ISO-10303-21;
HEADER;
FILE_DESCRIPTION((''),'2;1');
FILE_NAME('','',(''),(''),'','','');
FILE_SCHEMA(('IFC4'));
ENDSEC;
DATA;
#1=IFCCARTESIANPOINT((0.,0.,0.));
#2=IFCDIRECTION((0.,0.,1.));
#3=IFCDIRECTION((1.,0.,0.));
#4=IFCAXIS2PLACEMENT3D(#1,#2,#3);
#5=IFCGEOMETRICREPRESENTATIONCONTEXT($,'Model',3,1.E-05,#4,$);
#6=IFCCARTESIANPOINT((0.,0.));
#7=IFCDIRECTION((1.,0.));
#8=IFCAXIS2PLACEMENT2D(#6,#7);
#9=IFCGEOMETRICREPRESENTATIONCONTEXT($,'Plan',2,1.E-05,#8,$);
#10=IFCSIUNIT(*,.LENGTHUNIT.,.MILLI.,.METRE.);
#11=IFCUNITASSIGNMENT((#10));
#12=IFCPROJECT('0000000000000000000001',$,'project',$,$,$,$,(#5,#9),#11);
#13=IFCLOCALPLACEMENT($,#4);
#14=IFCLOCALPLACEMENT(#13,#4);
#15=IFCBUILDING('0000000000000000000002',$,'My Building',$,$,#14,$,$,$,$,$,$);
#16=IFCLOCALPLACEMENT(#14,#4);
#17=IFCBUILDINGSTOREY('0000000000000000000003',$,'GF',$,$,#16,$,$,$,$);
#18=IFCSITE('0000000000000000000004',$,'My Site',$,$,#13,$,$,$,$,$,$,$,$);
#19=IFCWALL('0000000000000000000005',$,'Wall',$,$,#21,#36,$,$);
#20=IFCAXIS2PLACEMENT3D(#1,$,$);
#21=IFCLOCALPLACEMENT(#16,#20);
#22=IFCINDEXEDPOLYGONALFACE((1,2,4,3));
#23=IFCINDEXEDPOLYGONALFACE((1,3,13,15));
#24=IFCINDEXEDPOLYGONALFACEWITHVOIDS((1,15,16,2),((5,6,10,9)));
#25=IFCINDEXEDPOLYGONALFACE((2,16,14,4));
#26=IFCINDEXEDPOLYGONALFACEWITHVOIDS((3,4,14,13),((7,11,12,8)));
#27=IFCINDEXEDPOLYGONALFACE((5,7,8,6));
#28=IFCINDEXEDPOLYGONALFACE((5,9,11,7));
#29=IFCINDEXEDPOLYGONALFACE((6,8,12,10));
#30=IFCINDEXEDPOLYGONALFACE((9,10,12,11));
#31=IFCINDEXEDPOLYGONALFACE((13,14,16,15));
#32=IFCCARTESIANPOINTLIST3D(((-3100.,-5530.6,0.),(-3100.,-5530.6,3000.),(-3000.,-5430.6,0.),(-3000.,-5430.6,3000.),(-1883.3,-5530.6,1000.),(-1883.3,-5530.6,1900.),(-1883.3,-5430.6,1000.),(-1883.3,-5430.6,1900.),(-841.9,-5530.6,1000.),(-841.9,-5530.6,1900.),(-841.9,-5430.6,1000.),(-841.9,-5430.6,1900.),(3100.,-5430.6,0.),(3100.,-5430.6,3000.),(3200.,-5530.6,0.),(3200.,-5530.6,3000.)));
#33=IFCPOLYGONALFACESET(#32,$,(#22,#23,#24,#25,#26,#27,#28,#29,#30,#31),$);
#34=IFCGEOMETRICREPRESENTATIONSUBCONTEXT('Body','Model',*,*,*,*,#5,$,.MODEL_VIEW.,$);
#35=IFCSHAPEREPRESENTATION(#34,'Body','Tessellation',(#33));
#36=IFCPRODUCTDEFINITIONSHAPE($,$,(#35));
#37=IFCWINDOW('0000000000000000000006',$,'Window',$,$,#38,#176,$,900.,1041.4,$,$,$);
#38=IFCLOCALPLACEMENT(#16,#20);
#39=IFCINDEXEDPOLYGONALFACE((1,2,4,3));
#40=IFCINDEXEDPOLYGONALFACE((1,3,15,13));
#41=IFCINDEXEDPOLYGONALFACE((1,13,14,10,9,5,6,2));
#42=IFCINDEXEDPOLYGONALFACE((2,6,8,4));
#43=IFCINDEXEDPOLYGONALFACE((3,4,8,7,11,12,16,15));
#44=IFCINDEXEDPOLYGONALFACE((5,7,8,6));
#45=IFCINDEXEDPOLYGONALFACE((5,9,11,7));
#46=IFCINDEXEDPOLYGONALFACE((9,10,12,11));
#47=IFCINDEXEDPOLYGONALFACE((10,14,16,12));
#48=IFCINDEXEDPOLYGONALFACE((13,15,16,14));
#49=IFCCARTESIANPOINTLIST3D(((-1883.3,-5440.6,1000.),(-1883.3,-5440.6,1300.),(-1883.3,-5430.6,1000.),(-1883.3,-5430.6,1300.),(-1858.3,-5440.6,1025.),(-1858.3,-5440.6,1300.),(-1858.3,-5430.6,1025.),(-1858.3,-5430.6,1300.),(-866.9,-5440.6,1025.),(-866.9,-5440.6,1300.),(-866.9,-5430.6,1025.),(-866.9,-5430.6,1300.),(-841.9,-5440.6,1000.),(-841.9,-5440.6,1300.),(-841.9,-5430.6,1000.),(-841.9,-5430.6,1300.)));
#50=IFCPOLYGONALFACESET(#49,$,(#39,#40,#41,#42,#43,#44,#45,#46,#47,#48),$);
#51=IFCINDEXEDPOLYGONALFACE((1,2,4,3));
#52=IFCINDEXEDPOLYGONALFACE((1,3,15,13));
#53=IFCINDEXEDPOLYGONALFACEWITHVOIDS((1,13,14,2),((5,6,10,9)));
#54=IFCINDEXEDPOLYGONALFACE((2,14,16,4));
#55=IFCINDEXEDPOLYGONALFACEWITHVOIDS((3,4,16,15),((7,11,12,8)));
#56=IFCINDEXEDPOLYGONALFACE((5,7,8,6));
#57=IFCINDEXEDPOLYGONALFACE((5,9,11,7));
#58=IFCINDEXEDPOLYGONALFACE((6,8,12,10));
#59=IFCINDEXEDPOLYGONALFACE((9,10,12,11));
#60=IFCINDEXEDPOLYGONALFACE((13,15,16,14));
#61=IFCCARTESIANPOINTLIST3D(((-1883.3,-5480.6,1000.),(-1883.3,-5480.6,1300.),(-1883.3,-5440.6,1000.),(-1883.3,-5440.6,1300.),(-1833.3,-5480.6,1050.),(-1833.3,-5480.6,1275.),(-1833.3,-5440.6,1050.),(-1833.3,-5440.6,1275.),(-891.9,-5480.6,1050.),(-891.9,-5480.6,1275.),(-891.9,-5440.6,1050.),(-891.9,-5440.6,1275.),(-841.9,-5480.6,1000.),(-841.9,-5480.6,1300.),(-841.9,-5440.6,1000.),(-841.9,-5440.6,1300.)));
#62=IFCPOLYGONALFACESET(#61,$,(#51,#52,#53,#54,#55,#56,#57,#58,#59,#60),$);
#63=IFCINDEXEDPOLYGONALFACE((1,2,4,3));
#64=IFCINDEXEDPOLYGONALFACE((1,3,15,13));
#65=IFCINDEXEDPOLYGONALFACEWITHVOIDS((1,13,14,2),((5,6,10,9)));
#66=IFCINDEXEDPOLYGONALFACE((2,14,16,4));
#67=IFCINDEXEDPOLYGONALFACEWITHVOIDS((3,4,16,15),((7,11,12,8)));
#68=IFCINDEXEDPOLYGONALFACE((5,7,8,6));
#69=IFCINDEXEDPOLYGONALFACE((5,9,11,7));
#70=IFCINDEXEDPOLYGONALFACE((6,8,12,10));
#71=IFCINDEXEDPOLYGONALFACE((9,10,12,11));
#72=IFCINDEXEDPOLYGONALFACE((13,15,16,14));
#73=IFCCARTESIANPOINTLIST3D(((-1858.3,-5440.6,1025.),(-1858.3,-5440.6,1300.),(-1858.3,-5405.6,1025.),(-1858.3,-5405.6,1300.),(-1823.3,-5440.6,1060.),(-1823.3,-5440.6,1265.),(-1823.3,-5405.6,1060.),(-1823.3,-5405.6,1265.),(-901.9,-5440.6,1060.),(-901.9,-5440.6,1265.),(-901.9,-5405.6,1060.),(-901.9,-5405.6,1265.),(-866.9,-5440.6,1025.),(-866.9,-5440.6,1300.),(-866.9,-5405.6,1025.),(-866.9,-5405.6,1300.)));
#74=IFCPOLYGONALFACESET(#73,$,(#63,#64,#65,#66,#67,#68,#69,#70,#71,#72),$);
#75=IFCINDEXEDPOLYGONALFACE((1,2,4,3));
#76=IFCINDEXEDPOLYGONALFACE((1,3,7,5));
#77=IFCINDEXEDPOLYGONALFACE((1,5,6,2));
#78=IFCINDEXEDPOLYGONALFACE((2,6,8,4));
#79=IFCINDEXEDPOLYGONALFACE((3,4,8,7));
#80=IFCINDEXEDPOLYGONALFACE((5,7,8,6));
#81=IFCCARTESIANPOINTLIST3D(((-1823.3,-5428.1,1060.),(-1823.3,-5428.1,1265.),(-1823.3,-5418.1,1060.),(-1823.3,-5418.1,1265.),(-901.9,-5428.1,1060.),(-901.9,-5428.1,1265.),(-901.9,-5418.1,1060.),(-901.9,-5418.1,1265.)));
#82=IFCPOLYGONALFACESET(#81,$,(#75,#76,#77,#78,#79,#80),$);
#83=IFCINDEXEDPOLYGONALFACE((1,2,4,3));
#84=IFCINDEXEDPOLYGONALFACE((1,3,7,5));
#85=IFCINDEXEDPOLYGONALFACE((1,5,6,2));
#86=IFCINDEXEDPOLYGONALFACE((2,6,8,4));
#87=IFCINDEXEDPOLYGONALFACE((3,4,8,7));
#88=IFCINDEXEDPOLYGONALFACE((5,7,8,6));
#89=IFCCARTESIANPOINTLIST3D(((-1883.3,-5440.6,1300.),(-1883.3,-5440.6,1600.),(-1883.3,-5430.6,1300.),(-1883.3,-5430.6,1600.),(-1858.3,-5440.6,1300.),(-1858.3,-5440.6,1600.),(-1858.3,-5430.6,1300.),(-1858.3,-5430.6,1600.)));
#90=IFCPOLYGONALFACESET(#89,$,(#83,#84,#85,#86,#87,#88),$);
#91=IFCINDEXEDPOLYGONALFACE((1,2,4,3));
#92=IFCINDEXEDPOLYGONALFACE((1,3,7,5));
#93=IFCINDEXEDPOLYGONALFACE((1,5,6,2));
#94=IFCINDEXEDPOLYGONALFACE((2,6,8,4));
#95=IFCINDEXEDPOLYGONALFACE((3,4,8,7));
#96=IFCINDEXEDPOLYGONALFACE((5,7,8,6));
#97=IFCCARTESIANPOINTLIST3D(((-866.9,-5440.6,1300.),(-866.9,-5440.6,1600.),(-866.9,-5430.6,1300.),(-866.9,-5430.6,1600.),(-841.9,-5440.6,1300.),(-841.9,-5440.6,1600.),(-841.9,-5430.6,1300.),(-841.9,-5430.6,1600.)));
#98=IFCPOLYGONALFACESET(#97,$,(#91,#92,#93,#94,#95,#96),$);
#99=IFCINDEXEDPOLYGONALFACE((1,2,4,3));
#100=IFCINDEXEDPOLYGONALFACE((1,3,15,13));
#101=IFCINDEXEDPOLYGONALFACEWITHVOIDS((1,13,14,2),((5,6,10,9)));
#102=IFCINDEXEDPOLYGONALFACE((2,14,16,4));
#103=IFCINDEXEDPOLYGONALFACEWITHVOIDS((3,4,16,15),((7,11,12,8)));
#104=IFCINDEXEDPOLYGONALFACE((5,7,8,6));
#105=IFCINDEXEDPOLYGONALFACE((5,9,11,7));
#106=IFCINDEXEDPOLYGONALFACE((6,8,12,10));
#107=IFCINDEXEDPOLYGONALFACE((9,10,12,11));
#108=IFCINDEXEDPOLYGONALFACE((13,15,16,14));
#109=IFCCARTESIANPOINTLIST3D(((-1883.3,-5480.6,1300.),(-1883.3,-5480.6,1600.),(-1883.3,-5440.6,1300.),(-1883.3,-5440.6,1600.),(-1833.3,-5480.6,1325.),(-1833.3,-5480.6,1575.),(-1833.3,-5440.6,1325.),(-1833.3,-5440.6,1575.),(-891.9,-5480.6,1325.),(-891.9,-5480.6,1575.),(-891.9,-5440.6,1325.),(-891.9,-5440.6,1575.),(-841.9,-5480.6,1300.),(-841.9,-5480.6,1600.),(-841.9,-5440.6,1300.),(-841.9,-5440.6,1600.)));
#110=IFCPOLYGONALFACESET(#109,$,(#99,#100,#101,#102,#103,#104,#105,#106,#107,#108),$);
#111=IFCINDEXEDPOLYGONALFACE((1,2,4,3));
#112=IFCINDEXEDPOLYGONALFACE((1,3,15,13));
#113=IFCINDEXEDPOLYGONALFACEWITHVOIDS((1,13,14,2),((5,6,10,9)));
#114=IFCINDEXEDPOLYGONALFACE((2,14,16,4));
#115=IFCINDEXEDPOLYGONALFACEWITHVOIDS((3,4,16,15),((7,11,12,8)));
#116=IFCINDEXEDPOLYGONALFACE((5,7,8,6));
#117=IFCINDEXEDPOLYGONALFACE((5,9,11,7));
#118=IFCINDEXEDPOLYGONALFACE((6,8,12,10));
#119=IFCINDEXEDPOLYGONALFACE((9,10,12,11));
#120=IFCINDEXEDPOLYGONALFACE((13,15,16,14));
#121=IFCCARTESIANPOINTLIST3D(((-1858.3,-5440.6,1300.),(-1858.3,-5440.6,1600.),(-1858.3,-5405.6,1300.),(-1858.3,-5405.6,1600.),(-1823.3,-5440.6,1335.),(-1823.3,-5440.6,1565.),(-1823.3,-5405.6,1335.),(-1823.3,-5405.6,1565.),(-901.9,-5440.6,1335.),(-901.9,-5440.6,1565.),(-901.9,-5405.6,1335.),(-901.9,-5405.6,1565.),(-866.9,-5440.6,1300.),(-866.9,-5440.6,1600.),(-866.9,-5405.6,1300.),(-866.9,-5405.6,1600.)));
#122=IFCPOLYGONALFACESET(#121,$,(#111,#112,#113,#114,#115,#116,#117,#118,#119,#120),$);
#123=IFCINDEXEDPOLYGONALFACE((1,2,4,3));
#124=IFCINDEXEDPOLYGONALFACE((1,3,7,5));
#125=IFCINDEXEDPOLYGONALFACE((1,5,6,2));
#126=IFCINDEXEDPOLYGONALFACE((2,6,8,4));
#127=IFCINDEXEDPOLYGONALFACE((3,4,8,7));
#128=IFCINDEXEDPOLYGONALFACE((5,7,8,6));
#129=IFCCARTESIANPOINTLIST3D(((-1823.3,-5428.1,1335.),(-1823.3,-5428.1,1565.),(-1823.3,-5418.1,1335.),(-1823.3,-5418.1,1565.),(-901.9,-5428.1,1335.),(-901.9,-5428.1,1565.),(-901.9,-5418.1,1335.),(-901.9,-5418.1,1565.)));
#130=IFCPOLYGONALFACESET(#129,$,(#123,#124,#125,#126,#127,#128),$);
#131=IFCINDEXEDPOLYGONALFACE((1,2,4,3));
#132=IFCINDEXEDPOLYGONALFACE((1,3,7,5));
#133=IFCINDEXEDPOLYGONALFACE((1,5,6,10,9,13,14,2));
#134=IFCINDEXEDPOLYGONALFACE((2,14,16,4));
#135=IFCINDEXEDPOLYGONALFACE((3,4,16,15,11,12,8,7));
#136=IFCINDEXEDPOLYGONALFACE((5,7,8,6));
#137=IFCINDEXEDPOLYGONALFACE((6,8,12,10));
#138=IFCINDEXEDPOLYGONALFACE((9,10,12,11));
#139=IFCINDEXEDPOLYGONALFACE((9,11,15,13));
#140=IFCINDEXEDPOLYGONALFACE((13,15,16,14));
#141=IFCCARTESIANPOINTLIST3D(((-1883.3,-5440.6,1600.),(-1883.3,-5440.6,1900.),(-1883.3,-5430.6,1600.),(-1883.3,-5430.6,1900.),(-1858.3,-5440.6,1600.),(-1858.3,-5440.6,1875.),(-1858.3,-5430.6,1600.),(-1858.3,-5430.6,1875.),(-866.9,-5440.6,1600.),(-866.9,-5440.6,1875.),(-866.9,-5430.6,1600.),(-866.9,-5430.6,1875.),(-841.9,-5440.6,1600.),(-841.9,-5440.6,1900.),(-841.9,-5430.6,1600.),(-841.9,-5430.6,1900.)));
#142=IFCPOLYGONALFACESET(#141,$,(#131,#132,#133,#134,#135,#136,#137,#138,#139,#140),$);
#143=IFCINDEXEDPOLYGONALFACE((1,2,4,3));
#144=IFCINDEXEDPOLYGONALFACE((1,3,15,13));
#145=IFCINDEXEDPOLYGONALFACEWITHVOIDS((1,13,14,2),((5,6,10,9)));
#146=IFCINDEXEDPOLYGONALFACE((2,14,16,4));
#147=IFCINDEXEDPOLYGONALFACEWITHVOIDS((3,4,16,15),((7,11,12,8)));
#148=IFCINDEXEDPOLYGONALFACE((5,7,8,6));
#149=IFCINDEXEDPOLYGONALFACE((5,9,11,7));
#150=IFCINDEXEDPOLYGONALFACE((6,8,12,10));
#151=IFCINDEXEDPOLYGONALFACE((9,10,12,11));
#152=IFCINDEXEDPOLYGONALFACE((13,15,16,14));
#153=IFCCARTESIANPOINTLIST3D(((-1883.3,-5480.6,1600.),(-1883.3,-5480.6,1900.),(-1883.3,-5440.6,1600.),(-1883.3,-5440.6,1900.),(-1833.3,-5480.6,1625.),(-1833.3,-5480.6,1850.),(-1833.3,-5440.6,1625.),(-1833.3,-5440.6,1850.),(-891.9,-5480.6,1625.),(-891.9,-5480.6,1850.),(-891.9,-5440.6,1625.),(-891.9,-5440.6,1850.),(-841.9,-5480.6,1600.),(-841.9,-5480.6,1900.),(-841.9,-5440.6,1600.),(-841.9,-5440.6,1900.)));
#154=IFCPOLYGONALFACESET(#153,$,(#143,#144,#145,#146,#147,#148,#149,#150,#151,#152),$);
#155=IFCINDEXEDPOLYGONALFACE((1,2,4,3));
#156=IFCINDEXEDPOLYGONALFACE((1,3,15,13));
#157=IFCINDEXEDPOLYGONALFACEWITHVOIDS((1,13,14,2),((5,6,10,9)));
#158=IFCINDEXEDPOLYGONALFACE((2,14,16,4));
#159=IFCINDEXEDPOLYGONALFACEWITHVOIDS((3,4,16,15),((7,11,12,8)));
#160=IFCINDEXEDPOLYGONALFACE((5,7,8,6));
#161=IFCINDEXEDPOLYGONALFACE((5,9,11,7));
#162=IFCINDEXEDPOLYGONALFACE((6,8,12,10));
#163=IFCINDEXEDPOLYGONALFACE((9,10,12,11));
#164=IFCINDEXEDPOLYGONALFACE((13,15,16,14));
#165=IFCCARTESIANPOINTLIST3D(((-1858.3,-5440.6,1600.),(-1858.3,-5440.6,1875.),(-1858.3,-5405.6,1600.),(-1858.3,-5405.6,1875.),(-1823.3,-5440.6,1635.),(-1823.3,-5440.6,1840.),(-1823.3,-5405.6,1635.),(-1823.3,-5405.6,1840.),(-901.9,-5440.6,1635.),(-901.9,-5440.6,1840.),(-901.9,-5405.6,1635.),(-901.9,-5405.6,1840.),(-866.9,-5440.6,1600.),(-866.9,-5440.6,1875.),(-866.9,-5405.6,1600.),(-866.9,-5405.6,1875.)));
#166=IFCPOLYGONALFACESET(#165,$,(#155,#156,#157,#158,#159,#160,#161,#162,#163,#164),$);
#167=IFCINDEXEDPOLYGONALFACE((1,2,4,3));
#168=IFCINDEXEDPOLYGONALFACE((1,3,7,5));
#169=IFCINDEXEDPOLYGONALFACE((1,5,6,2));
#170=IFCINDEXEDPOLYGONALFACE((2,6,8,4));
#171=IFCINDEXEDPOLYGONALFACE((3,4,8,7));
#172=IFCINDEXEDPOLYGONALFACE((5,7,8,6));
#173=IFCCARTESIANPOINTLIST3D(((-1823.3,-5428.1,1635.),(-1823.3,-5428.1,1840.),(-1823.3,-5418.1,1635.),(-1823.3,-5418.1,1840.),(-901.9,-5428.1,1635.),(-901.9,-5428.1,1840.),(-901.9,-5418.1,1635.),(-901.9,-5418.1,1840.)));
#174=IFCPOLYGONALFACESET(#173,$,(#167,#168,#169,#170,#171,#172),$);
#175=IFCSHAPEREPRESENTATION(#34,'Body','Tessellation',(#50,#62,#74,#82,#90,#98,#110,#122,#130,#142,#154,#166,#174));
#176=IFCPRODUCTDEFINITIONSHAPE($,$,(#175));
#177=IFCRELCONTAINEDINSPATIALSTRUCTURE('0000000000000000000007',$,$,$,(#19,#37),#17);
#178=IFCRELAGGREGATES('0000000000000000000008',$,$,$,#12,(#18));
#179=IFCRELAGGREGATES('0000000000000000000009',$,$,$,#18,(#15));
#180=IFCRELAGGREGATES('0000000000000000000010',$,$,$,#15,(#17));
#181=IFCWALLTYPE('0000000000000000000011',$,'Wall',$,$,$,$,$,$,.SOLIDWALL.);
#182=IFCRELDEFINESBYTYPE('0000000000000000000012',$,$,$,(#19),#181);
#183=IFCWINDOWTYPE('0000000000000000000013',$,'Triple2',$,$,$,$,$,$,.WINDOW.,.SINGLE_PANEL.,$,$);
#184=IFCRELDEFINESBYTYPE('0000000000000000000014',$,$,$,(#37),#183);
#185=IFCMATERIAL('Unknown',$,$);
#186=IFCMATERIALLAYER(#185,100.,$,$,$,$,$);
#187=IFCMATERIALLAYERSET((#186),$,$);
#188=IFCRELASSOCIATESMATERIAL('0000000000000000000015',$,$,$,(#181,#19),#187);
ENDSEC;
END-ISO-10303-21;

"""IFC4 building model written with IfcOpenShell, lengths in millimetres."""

from ifc_helpers import new_model, entity, si_unit, frame, origin_with_axes, origin_2d_with_axis, place, context, subcontext, project, spatial, line, indexed_curve, outline, extrude, shape, source, transform, mapped, material, layer, layer_set, layer_usage, type_object, type_shapes, element, fill, save


model = new_model("IFC4")

# Units and contexts
model_context = context("Model", 3, precision=1e-05, world=origin_with_axes())
plan_context = context("Plan", 2, precision=1e-05, world=origin_2d_with_axis())
body_context_1 = subcontext(model_context, "Body", "Model", "MODEL_VIEW")
body_context_2 = subcontext(plan_context, "Body", "Plan", "PLAN_VIEW")
ifc_project = project(units=[si_unit("LENGTHUNIT", "METRE", prefix="MILLI")], contexts=[model_context, plan_context])

# Site, building, storey
site_placement = place(None, origin_with_axes())
site = spatial("IfcSite", under=ifc_project, at=site_placement, Name="My Site")
building_placement = place(site_placement, origin_with_axes())
building = spatial("IfcBuilding", under=site, at=building_placement, Name="My Building")
storey_placement = place(building_placement, origin_with_axes())
storey = spatial("IfcBuildingStorey", under=building, at=storey_placement, Name="GF")

# Shared definitions
ifc_material = material(Name="Unknown")

# Shared definitions
ifc_layer_1 = layer(ifc_material, 100.0)
ifc_layer_set_1 = layer_set([ifc_layer_1])
wall_type = type_object("IfcWallType", Name="Wall", PredefinedType="SOLIDWALL", material=ifc_layer_set_1)

# Wall, opening, window
ifc_layer_usage_1 = layer_usage(ifc_layer_set_1, "AXIS2", "POSITIVE", 0.0)
wall_1_placement = place(storey_placement, frame((3100.0, -5430.6, 0.0), z_axis=(0.0, 0.0, 1.0), x_axis=(-1.0, 0.0, 0.0)))
wall_1 = element("IfcWall", 1, at=wall_1_placement, inside=storey, type_object=wall_type, material=ifc_layer_usage_1, Name="Wall", context=body_context_1, shape_type="SweptSolid", body=[
    extrude(outline(indexed_curve([(0.0, 0.0), (-100.0, 100.0), (6200.0, 100.0), (6100.0, 0.0)], segments=[line(1, 2, 3, 4, 1)])), origin_with_axes(), (0.0, 0.0, 1.0), 3000.0),
])
shared_shape_1 = source(origin_with_axes(), body_context_1, "Body", "SweptSolid", [
    extrude(outline(indexed_curve([(0.0, 0.0), (1041.4, 0.0), (1041.4, 900.0), (0.0, 900.0)], segments=[line(1, 2, 3, 4, 1)])), frame((0.0, -600.0, 0.0), z_axis=(0.0, -1.0, 0.0), x_axis=(1.0, 0.0, 0.0)), (0.0, 0.0, -1.0), 1200.0),
])
opening_1_placement = place(wall_1_placement, frame((4983.3, 100.0, 1000.0), z_axis=(0.0, 0.0, 1.0), x_axis=(-1.0, 0.0, 0.0)))
opening_1 = element("IfcOpeningElement", 2, at=opening_1_placement, cuts=wall_1, PredefinedType="OPENING", context=body_context_1, shape_type="MappedRepresentation", body=[
    mapped(shared_shape_1, transform((0.0, 0.0, 0.0), x_axis=(1.0, 0.0, 0.0), y_axis=(0.0, 1.0, 0.0), z_axis=(0.0, 0.0, 1.0), scale=1.0)),
])
window_type_1 = type_object("IfcWindowType", Name="Triple2", PartitioningType="SINGLE_PANEL", PredefinedType="WINDOW")
shared_shape_2 = source(origin_with_axes(), body_context_1, "Body", "SweptSolid", [
    extrude(outline(indexed_curve([(1041.4, 300.0), (1041.4, 0.0), (0.0, 0.0), (0.0, 300.0), (25.0, 300.0), (25.0, 25.0), (1016.4, 25.0), (1016.4, 300.0)], segments=[line(1, 2, 3, 4, 5, 6, 7, 8, 1)])), frame((0.0, 90.0, 0.0), z_axis=(0.0, -1.0, 0.0), x_axis=(1.0, 0.0, 0.0)), (0.0, 0.0, -1.0), 10.0),
    extrude(outline(indexed_curve([(0.0, 0.0), (1041.4, 0.0), (1041.4, 300.0), (0.0, 300.0)], segments=[line(1, 2, 3, 4, 1)]), holes=[indexed_curve([(50.0, 50.0), (991.4, 50.0), (991.4, 275.0), (50.0, 275.0)], segments=[line(1, 2, 3, 4, 1)])]), frame((0.0, 50.0, 0.0), z_axis=(0.0, -1.0, 0.0), x_axis=(1.0, 0.0, 0.0)), (0.0, 0.0, -1.0), 40.0),
    extrude(outline(indexed_curve([(0.0, 0.0), (991.4, 0.0), (991.4, 275.0), (0.0, 275.0)], segments=[line(1, 2, 3, 4, 1)]), holes=[indexed_curve([(35.0, 35.0), (956.4, 35.0), (956.4, 240.0), (35.0, 240.0)], segments=[line(1, 2, 3, 4, 1)])]), frame((25.0, 90.0, 25.0), z_axis=(0.0, -1.0, 0.0), x_axis=(1.0, 0.0, 0.0)), (0.0, 0.0, -1.0), 35.0),
    extrude(outline(indexed_curve([(35.0, 35.0), (956.4, 35.0), (956.4, 240.0), (35.0, 240.0)], segments=[line(1, 2, 3, 4, 1)])), frame((25.0, 102.5, 25.0), z_axis=(0.0, -1.0, 0.0), x_axis=(1.0, 0.0, 0.0)), (0.0, 0.0, -1.0), 10.0),
    extrude(outline(indexed_curve([(0.0, 0.0), (0.0, 300.0), (25.0, 300.0), (25.0, 0.0)], segments=[line(1, 2, 3, 4, 1)])), frame((0.0, 90.0, 300.0), z_axis=(0.0, -1.0, 0.0), x_axis=(1.0, 0.0, 0.0)), (0.0, 0.0, -1.0), 10.0),
    extrude(outline(indexed_curve([(1041.4, 300.0), (1041.4, 0.0), (1016.4, 0.0), (1016.4, 300.0)], segments=[line(1, 2, 3, 4, 1)])), frame((0.0, 90.0, 300.0), z_axis=(0.0, -1.0, 0.0), x_axis=(1.0, 0.0, 0.0)), (0.0, 0.0, -1.0), 10.0),
    extrude(outline(indexed_curve([(0.0, 0.0), (1041.4, 0.0), (1041.4, 300.0), (0.0, 300.0)], segments=[line(1, 2, 3, 4, 1)]), holes=[indexed_curve([(50.0, 25.0), (991.4, 25.0), (991.4, 275.0), (50.0, 275.0)], segments=[line(1, 2, 3, 4, 1)])]), frame((0.0, 50.0, 300.0), z_axis=(0.0, -1.0, 0.0), x_axis=(1.0, 0.0, 0.0)), (0.0, 0.0, -1.0), 40.0),
    extrude(outline(indexed_curve([(0.0, 0.0), (991.4, 0.0), (991.4, 300.0), (0.0, 300.0)], segments=[line(1, 2, 3, 4, 1)]), holes=[indexed_curve([(35.0, 35.0), (956.4, 35.0), (956.4, 265.0), (35.0, 265.0)], segments=[line(1, 2, 3, 4, 1)])]), frame((25.0, 90.0, 300.0), z_axis=(0.0, -1.0, 0.0), x_axis=(1.0, 0.0, 0.0)), (0.0, 0.0, -1.0), 35.0),
    extrude(outline(indexed_curve([(35.0, 35.0), (956.4, 35.0), (956.4, 265.0), (35.0, 265.0)], segments=[line(1, 2, 3, 4, 1)])), frame((25.0, 102.5, 300.0), z_axis=(0.0, -1.0, 0.0), x_axis=(1.0, 0.0, 0.0)), (0.0, 0.0, -1.0), 10.0),
    extrude(outline(indexed_curve([(0.0, 0.0), (0.0, 300.0), (1041.4, 300.0), (1041.4, 0.0), (1016.4, 0.0), (1016.4, 275.0), (25.0, 275.0), (25.0, 0.0)], segments=[line(1, 2, 3, 4, 5, 6, 7, 8, 1)])), frame((0.0, 90.0, 600.0), z_axis=(0.0, -1.0, 0.0), x_axis=(1.0, 0.0, 0.0)), (0.0, 0.0, -1.0), 10.0),
    extrude(outline(indexed_curve([(0.0, 0.0), (1041.4, 0.0), (1041.4, 300.0), (0.0, 300.0)], segments=[line(1, 2, 3, 4, 1)]), holes=[indexed_curve([(50.0, 25.0), (991.4, 25.0), (991.4, 250.0), (50.0, 250.0)], segments=[line(1, 2, 3, 4, 1)])]), frame((0.0, 50.0, 600.0), z_axis=(0.0, -1.0, 0.0), x_axis=(1.0, 0.0, 0.0)), (0.0, 0.0, -1.0), 40.0),
    extrude(outline(indexed_curve([(0.0, 0.0), (991.4, 0.0), (991.4, 275.0), (0.0, 275.0)], segments=[line(1, 2, 3, 4, 1)]), holes=[indexed_curve([(35.0, 35.0), (956.4, 35.0), (956.4, 240.0), (35.0, 240.0)], segments=[line(1, 2, 3, 4, 1)])]), frame((25.0, 90.0, 600.0), z_axis=(0.0, -1.0, 0.0), x_axis=(1.0, 0.0, 0.0)), (0.0, 0.0, -1.0), 35.0),
    extrude(outline(indexed_curve([(35.0, 35.0), (956.4, 35.0), (956.4, 240.0), (35.0, 240.0)], segments=[line(1, 2, 3, 4, 1)])), frame((25.0, 102.5, 600.0), z_axis=(0.0, -1.0, 0.0), x_axis=(1.0, 0.0, 0.0)), (0.0, 0.0, -1.0), 10.0),
])
shared_shape_3 = source(origin_with_axes(), body_context_2, "Body", "Curve2D", [
    entity("IfcIndexedPolyCurve", entity("IfcCartesianPointList2D", [[50.0, 50.0], [991.4, 50.0]])),
    entity("IfcIndexedPolyCurve", entity("IfcCartesianPointList2D", [[0.0, 100.0], [25.0, 100.0], [25.0, 90.0], [50.0, 90.0], [50.0, 50.0], [0.0, 50.0]]), [entity("IfcLineIndex", [1, 2, 3, 4, 5, 6, 1])]),
    entity("IfcIndexedPolyCurve", entity("IfcCartesianPointList2D", [[1041.4, 100.0], [1016.4, 100.0], [1016.4, 90.0], [991.4, 90.0], [991.4, 50.0], [1041.4, 50.0]]), [entity("IfcLineIndex", [1, 2, 3, 4, 5, 6, 1])]),
    entity("IfcIndexedPolyCurve", entity("IfcCartesianPointList2D", [[25.0, 90.0], [60.0, 90.0], [60.0, 125.0], [25.0, 125.0]]), [entity("IfcLineIndex", [1, 2, 3, 4, 1])]),
    entity("IfcIndexedPolyCurve", entity("IfcCartesianPointList2D", [[1016.4, 90.0], [981.4, 90.0], [981.4, 125.0], [1016.4, 125.0]]), [entity("IfcLineIndex", [1, 2, 3, 4, 1])]),
    entity("IfcIndexedPolyCurve", entity("IfcCartesianPointList2D", [[60.0, 90.0], [981.4, 90.0]])),
    entity("IfcIndexedPolyCurve", entity("IfcCartesianPointList2D", [[60.0, 125.0], [981.4, 125.0]])),
    entity("IfcIndexedPolyCurve", entity("IfcCartesianPointList2D", [[60.0, 107.5], [981.4, 107.5]])),
])
type_shapes(window_type_1, [shared_shape_2, shared_shape_3])
window_1_placement = place(opening_1_placement, frame((0.0, 0.0, 0.0), z_axis=(0.0, 0.0, 1.0), x_axis=(1.0, 0.0, 0.0)))
window_1 = element("IfcWindow", 3, at=window_1_placement, inside=storey, type_object=window_type_1, Name="Window", OverallHeight=900.0, OverallWidth=1041.4, shapes=[
    shape(body_context_1, "Body", "MappedRepresentation", [mapped(shared_shape_2, transform((0.0, 0.0, 0.0), x_axis=(1.0, 0.0, 0.0), y_axis=(0.0, 1.0, 0.0), z_axis=(0.0, 0.0, 1.0), scale=1.0))]),
    shape(body_context_2, "Body", "MappedRepresentation", [mapped(shared_shape_3, transform((0.0, 0.0, 0.0), x_axis=(1.0, 0.0, 0.0), y_axis=(0.0, 1.0, 0.0), z_axis=(0.0, 0.0, 1.0), scale=1.0))]),
])
fill(opening_1, window_1)

save(model, "model.ifc")
